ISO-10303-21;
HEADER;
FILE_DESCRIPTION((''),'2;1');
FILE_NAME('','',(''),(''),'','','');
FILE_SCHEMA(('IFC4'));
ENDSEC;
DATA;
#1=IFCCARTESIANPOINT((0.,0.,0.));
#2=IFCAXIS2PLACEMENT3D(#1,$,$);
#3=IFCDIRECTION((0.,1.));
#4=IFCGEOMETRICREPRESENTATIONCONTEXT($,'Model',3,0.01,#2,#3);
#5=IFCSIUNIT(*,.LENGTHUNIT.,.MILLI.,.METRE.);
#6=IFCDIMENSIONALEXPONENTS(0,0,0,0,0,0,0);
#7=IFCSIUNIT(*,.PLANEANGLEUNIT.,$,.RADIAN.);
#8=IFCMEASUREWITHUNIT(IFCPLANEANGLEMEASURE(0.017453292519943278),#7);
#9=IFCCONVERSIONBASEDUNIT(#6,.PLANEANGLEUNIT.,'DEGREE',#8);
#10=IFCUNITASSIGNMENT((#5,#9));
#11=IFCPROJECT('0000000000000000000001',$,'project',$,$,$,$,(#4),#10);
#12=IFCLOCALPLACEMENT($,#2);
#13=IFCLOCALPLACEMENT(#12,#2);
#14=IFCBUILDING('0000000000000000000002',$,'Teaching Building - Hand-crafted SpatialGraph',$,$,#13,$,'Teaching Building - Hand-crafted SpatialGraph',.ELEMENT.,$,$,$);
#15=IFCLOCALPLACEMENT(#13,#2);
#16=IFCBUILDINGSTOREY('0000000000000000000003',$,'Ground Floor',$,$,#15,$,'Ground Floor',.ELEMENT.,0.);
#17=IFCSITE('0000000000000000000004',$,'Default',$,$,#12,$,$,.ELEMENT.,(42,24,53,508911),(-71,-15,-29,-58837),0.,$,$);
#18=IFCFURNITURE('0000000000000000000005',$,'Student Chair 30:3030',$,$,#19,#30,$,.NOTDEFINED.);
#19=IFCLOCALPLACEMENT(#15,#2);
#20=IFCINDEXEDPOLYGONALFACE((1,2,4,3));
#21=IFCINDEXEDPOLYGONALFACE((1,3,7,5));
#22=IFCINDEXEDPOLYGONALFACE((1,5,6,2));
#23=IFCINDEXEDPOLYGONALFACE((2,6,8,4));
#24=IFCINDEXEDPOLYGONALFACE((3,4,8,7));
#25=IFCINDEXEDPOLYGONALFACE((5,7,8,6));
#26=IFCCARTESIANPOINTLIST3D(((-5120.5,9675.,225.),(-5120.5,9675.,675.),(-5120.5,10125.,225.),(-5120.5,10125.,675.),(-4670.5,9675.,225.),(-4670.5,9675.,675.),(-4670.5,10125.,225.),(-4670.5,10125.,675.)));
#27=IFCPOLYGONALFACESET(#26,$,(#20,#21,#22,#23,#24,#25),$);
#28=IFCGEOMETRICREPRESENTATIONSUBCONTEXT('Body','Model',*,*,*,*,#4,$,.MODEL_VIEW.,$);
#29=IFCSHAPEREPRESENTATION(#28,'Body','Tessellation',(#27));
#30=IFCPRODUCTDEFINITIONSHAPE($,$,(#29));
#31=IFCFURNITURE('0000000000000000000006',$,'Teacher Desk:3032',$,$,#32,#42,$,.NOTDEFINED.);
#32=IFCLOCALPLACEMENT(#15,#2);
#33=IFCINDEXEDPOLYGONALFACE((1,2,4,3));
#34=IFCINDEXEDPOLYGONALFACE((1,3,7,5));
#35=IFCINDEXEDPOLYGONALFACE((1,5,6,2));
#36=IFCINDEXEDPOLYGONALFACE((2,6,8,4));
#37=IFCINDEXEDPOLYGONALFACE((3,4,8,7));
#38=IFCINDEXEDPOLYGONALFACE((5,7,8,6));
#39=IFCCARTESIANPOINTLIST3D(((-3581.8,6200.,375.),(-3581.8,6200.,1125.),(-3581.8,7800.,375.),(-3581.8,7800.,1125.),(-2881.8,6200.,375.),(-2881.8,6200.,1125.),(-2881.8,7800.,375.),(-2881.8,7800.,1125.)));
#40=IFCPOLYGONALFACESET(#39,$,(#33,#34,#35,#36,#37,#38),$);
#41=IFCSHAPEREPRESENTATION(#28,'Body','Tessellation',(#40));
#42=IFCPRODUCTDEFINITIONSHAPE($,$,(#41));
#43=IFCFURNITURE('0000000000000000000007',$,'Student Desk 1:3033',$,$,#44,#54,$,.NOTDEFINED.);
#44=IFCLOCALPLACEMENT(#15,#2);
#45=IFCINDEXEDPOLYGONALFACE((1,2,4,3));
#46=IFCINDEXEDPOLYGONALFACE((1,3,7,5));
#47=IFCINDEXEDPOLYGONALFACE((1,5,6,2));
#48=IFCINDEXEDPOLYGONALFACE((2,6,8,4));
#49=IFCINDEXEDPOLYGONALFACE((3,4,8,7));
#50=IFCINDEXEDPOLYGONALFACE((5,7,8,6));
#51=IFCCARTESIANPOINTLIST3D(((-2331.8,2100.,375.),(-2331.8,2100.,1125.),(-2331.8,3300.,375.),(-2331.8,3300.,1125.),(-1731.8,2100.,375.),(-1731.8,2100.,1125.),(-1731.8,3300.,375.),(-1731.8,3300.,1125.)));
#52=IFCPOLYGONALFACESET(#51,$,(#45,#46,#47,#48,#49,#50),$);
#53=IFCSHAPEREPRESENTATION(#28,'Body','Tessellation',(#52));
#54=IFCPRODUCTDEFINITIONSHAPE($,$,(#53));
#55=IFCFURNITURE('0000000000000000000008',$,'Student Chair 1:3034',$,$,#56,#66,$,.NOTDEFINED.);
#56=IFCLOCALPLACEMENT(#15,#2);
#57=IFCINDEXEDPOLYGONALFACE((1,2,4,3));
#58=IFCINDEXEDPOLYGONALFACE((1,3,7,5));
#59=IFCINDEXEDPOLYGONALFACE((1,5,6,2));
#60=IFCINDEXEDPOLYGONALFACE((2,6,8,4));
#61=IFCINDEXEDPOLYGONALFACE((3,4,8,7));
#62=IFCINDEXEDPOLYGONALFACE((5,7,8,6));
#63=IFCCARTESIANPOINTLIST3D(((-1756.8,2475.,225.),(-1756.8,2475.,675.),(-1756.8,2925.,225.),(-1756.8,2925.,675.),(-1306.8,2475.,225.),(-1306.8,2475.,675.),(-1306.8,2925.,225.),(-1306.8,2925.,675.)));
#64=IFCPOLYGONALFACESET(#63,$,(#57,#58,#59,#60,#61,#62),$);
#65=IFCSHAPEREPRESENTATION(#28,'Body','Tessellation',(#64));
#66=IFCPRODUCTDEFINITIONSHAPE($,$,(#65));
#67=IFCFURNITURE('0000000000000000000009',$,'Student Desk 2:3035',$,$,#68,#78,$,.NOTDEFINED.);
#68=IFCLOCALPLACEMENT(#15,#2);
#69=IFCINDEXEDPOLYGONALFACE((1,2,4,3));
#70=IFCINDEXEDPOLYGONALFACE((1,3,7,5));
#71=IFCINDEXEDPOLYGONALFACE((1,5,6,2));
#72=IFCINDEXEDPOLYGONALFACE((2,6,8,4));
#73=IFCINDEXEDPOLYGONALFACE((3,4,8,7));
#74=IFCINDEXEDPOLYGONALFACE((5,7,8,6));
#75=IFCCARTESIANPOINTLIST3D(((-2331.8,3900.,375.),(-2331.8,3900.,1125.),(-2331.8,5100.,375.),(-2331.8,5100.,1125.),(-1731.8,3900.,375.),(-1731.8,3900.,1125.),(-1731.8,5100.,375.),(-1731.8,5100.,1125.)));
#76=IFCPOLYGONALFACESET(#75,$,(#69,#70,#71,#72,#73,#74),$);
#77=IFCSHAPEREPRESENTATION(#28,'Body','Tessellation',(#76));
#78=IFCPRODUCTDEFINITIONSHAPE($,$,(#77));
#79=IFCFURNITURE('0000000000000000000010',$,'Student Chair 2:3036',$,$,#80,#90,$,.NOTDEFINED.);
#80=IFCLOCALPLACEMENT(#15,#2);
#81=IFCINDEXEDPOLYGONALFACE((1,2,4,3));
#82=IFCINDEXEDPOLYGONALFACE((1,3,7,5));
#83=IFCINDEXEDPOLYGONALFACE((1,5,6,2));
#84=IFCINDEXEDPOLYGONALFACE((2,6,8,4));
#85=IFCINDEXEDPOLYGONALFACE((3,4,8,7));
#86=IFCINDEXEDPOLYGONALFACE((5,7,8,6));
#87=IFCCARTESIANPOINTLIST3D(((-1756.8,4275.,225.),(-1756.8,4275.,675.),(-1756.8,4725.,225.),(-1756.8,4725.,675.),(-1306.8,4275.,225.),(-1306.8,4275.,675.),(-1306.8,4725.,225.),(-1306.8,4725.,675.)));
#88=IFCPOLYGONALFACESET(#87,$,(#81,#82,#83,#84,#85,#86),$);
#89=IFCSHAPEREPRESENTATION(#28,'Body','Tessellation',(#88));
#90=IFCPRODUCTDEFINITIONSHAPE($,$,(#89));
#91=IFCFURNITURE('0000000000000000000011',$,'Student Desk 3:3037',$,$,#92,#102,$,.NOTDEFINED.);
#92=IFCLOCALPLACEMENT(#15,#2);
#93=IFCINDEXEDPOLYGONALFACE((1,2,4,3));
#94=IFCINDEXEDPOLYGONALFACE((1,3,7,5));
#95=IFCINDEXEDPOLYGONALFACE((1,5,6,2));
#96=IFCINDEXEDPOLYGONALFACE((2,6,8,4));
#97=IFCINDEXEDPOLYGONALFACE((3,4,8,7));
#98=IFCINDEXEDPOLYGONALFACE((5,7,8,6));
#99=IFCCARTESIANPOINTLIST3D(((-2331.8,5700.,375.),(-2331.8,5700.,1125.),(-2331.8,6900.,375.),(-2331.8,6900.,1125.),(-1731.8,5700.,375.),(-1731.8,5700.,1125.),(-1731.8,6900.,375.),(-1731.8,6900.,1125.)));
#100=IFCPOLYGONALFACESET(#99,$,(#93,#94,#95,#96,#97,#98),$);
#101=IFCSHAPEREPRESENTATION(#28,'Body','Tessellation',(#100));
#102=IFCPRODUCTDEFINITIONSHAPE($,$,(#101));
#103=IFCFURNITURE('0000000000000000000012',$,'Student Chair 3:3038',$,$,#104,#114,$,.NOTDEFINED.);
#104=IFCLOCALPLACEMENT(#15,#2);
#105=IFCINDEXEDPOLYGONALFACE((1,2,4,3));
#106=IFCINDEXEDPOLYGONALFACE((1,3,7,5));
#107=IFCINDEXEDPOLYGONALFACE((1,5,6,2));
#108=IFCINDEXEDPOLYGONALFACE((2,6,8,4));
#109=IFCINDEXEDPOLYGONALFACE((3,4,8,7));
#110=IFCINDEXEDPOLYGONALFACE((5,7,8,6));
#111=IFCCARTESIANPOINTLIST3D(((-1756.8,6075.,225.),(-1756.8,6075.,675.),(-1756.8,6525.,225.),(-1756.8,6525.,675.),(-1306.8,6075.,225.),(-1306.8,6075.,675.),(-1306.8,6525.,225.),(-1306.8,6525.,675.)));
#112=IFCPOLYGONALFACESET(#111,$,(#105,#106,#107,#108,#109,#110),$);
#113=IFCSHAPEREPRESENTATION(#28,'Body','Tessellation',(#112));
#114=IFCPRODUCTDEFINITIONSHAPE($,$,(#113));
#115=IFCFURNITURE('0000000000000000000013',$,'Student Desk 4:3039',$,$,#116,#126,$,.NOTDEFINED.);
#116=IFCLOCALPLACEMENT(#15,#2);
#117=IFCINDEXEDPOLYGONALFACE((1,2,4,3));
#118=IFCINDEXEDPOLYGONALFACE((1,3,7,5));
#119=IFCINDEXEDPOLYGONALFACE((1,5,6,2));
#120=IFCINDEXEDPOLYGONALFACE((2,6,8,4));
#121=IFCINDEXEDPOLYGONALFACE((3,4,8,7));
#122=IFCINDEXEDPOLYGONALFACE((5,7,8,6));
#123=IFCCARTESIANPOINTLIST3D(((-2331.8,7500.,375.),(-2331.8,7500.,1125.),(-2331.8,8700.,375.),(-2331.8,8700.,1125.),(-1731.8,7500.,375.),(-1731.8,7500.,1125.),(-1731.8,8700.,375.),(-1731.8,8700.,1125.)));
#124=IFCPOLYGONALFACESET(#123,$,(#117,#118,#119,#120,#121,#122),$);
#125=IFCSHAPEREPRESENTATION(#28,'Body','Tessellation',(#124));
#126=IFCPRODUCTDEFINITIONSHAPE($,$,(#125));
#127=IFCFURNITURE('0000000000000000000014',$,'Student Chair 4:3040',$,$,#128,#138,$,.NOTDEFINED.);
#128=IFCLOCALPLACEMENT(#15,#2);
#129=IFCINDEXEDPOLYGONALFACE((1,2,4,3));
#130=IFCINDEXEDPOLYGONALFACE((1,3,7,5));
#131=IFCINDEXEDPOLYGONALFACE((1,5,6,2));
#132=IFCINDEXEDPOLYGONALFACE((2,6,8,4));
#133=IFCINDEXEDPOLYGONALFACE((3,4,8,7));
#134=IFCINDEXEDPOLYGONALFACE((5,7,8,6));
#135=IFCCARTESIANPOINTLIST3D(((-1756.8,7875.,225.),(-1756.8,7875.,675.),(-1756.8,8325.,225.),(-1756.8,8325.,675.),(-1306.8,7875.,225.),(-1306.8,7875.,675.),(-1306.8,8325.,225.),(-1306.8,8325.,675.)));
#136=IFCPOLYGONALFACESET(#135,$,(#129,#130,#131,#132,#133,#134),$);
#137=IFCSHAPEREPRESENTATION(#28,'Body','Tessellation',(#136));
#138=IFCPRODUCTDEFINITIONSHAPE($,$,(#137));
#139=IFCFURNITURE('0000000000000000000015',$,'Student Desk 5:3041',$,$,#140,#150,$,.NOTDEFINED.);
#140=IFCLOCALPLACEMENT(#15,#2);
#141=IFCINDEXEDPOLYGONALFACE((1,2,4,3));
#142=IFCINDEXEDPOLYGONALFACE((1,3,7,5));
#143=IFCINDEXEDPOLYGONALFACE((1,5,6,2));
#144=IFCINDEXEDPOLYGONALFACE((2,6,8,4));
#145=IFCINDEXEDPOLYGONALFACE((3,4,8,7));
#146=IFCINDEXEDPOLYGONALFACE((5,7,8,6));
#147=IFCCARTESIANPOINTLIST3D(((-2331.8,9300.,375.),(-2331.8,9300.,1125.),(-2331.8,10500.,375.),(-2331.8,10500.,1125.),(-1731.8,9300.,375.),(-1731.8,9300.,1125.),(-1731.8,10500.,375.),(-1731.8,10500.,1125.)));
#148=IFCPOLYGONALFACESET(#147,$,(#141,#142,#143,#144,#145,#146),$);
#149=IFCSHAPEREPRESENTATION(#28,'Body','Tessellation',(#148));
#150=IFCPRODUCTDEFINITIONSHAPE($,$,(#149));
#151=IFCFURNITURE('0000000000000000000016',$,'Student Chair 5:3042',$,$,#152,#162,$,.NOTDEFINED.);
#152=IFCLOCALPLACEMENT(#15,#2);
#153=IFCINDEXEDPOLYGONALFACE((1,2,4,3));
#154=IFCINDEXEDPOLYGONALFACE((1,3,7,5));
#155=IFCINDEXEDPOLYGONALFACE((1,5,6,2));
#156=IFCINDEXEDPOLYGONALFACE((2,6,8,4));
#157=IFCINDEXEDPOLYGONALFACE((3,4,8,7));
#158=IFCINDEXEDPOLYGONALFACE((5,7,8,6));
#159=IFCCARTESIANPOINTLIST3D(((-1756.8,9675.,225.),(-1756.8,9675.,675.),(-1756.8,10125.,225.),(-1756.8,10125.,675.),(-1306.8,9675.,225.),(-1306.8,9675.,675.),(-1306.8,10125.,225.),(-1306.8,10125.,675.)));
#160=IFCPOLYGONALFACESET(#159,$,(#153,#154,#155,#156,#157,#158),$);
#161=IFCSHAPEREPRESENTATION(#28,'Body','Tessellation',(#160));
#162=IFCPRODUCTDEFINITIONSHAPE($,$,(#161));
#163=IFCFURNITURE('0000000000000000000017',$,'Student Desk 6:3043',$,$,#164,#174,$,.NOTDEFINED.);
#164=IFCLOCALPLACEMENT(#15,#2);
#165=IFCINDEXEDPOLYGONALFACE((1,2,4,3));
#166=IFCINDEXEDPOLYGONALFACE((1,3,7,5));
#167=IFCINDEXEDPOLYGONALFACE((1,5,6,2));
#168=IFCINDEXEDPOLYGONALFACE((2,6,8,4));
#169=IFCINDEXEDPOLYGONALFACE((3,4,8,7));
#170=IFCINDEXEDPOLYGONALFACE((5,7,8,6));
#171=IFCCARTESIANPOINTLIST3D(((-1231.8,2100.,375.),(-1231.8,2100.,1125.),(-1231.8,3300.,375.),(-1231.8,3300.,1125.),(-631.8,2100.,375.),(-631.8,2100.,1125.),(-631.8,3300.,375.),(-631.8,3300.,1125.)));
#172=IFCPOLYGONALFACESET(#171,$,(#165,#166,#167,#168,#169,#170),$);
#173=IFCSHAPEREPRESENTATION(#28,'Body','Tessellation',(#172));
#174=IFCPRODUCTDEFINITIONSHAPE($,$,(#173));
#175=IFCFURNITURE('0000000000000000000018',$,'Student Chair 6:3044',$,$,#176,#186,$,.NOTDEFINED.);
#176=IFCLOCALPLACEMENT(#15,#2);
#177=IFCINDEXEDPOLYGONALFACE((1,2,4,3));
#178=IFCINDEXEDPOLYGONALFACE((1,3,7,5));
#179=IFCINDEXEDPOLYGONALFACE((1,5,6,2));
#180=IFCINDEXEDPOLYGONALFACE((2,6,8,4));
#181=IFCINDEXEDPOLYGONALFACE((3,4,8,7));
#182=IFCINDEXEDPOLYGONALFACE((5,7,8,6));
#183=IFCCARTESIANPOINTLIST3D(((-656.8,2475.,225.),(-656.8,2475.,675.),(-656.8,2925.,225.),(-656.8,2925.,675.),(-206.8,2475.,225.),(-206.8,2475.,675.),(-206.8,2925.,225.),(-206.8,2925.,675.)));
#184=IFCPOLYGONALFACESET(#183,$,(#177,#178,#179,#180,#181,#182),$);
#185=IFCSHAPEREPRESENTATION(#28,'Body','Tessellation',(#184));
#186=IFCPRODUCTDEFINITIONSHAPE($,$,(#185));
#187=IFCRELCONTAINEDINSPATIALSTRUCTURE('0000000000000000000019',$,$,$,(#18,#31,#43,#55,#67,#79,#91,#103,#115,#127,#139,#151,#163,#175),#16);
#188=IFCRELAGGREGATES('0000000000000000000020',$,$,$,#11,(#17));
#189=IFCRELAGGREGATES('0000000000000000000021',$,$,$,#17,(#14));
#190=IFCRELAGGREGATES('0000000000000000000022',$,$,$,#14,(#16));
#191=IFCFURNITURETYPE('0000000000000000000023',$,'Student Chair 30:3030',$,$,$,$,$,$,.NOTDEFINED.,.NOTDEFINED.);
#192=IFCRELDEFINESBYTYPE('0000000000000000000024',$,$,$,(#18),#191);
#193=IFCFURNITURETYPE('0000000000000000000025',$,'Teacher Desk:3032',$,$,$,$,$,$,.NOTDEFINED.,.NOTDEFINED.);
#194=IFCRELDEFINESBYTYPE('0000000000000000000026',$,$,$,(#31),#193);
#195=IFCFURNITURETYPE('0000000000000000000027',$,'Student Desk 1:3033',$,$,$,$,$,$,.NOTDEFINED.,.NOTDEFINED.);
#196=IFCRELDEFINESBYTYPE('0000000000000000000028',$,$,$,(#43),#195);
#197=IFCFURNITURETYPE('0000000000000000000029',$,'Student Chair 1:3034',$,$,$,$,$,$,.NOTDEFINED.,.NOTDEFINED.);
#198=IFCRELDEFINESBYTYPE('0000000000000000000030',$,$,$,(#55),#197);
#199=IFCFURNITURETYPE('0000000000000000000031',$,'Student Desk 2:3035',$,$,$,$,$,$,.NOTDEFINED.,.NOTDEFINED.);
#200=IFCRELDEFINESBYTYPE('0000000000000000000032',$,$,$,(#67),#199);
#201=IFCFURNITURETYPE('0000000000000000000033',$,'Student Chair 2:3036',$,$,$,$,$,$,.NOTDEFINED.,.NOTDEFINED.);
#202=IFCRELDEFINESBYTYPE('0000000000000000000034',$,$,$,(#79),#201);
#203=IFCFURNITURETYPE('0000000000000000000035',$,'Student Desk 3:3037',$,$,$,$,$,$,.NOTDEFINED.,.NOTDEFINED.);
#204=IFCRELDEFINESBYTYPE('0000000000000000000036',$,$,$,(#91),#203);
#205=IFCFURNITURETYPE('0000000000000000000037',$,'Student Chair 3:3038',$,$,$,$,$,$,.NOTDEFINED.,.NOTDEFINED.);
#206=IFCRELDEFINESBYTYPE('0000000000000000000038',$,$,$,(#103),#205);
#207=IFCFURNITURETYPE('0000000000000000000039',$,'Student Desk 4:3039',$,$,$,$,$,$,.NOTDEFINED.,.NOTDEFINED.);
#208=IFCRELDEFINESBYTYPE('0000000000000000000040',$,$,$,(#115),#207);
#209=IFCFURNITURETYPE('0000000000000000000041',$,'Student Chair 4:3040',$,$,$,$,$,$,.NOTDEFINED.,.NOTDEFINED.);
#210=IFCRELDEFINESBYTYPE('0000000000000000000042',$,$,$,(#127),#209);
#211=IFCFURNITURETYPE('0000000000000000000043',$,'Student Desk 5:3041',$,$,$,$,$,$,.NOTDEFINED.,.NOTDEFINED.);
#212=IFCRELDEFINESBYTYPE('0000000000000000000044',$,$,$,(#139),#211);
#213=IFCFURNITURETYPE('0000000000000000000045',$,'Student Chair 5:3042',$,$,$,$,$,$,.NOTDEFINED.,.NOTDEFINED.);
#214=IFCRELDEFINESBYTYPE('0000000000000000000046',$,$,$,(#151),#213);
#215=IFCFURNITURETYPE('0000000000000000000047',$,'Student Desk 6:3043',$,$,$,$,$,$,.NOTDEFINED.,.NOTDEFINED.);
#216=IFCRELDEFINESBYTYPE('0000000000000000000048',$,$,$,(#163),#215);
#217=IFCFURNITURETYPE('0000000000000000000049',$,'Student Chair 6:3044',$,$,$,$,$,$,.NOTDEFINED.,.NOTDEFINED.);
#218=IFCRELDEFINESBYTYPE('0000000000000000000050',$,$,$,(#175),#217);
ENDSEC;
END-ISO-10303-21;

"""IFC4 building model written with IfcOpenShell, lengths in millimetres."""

from ifc_helpers import new_model, entity, si_unit, converted_unit, direction, frame, frame_2d, origin, origin_2d_with_axis, place, context, subcontext, project, spatial, rectangle, extrude, type_object, element, save


model = new_model("IFC4")

# Units and contexts
model_context = context("Model", 3, precision=0.01, world=origin(), true_north=direction((0.0, 1.0)))
body_context = subcontext(model_context, "Body", "Model", "MODEL_VIEW")
ifc_project = project(units=[si_unit("LENGTHUNIT", "METRE", prefix="MILLI"), converted_unit("PLANEANGLEUNIT", "DEGREE", entity("IfcPlaneAngleMeasure", 0.017453292519943278), si_unit("PLANEANGLEUNIT", "RADIAN"), dimensions=[0, 0, 0, 0, 0, 0, 0])], contexts=[model_context])

# Site, building, storey
site_placement = place(None, origin())
site = spatial("IfcSite", under=ifc_project, at=site_placement, Name="Default", CompositionType="ELEMENT", RefLatitude=(42, 24, 53, 508911), RefLongitude=(-71, -15, -29, -58837), RefElevation=0.0)
building_placement = place(site_placement, origin())
building = spatial("IfcBuilding", under=site, at=building_placement, Name="Teaching Building - Hand-crafted SpatialGraph", LongName="Teaching Building - Hand-crafted SpatialGraph", CompositionType="ELEMENT")
storey_placement = place(building_placement, origin())
storey = spatial("IfcBuildingStorey", under=building, at=storey_placement, Name="Ground Floor", LongName="Ground Floor", CompositionType="ELEMENT", Elevation=0.0)

# Furniture
furniture_type_1 = type_object("IfcFurnitureType", Name="Student Chair 30:3030", PredefinedType="NOTDEFINED")
furniture_1_placement = place(storey_placement, origin())
element("IfcFurniture", 1, at=furniture_1_placement, inside=storey, type_object=furniture_type_1, Name="Student Chair 30:3030", PredefinedType="NOTDEFINED", context=body_context, shape_type="SweptSolid", body=[
    extrude(rectangle(XDim=450.0, YDim=450.0, at=frame_2d((0.0, 0.0), x_axis=(1.0, 0.0))), frame((-4895.5, 9900.0, 225.0)), (0.0, 0.0, 1.0), 450.0),
])
furniture_type_2 = type_object("IfcFurnitureType", Name="Teacher Desk:3032", PredefinedType="NOTDEFINED")
furniture_2_placement = place(storey_placement, origin())
element("IfcFurniture", 2, at=furniture_2_placement, inside=storey, type_object=furniture_type_2, Name="Teacher Desk:3032", PredefinedType="NOTDEFINED", context=body_context, shape_type="SweptSolid", body=[
    extrude(rectangle(XDim=1600.0, YDim=700.0, at=origin_2d_with_axis()), frame((-3231.8, 7000.0, 375.0), z_axis=(0.0, 0.0, 1.0), x_axis=(0.0, 1.0, 0.0)), (0.0, 0.0, 1.0), 750.0),
])
furniture_type_3 = type_object("IfcFurnitureType", Name="Student Desk 1:3033", PredefinedType="NOTDEFINED")
furniture_3_placement = place(storey_placement, origin())
element("IfcFurniture", 3, at=furniture_3_placement, inside=storey, type_object=furniture_type_3, Name="Student Desk 1:3033", PredefinedType="NOTDEFINED", context=body_context, shape_type="SweptSolid", body=[
    extrude(rectangle(XDim=1200.0, YDim=600.0, at=origin_2d_with_axis()), frame((-2031.8, 2700.0, 375.0), z_axis=(0.0, 0.0, 1.0), x_axis=(0.0, 1.0, 0.0)), (0.0, 0.0, 1.0), 750.0),
])
furniture_type_4 = type_object("IfcFurnitureType", Name="Student Chair 1:3034", PredefinedType="NOTDEFINED")
furniture_4_placement = place(storey_placement, origin())
element("IfcFurniture", 4, at=furniture_4_placement, inside=storey, type_object=furniture_type_4, Name="Student Chair 1:3034", PredefinedType="NOTDEFINED", context=body_context, shape_type="SweptSolid", body=[
    extrude(rectangle(XDim=450.0, YDim=450.0, at=origin_2d_with_axis()), frame((-1531.8, 2700.0, 225.0)), (0.0, 0.0, 1.0), 450.0),
])
furniture_type_5 = type_object("IfcFurnitureType", Name="Student Desk 2:3035", PredefinedType="NOTDEFINED")
furniture_5_placement = place(storey_placement, origin())
element("IfcFurniture", 5, at=furniture_5_placement, inside=storey, type_object=furniture_type_5, Name="Student Desk 2:3035", PredefinedType="NOTDEFINED", context=body_context, shape_type="SweptSolid", body=[
    extrude(rectangle(XDim=1200.0, YDim=600.0, at=frame_2d((0.0, 0.0), x_axis=(1.0, 0.0))), frame((-2031.8, 4500.0, 375.0), z_axis=(0.0, 0.0, 1.0), x_axis=(0.0, 1.0, 0.0)), (0.0, 0.0, 1.0), 750.0),
])
furniture_type_6 = type_object("IfcFurnitureType", Name="Student Chair 2:3036", PredefinedType="NOTDEFINED")
furniture_6_placement = place(storey_placement, origin())
element("IfcFurniture", 6, at=furniture_6_placement, inside=storey, type_object=furniture_type_6, Name="Student Chair 2:3036", PredefinedType="NOTDEFINED", context=body_context, shape_type="SweptSolid", body=[
    extrude(rectangle(XDim=450.0, YDim=450.0, at=origin_2d_with_axis()), frame((-1531.8, 4500.0, 225.0)), (0.0, 0.0, 1.0), 450.0),
])
furniture_type_7 = type_object("IfcFurnitureType", Name="Student Desk 3:3037", PredefinedType="NOTDEFINED")
furniture_7_placement = place(storey_placement, origin())
element("IfcFurniture", 7, at=furniture_7_placement, inside=storey, type_object=furniture_type_7, Name="Student Desk 3:3037", PredefinedType="NOTDEFINED", context=body_context, shape_type="SweptSolid", body=[
    extrude(rectangle(XDim=1200.0, YDim=600.0, at=origin_2d_with_axis()), frame((-2031.8, 6300.0, 375.0), z_axis=(0.0, 0.0, 1.0), x_axis=(0.0, 1.0, 0.0)), (0.0, 0.0, 1.0), 750.0),
])
furniture_type_8 = type_object("IfcFurnitureType", Name="Student Chair 3:3038", PredefinedType="NOTDEFINED")
furniture_8_placement = place(storey_placement, origin())
element("IfcFurniture", 8, at=furniture_8_placement, inside=storey, type_object=furniture_type_8, Name="Student Chair 3:3038", PredefinedType="NOTDEFINED", context=body_context, shape_type="SweptSolid", body=[
    extrude(rectangle(XDim=450.0, YDim=450.0, at=origin_2d_with_axis()), frame((-1531.8, 6300.0, 225.0)), (0.0, 0.0, 1.0), 450.0),
])
furniture_type_9 = type_object("IfcFurnitureType", Name="Student Desk 4:3039", PredefinedType="NOTDEFINED")
furniture_9_placement = place(storey_placement, origin())
element("IfcFurniture", 9, at=furniture_9_placement, inside=storey, type_object=furniture_type_9, Name="Student Desk 4:3039", PredefinedType="NOTDEFINED", context=body_context, shape_type="SweptSolid", body=[
    extrude(rectangle(XDim=1200.0, YDim=600.0, at=origin_2d_with_axis()), frame((-2031.8, 8100.0, 375.0), z_axis=(0.0, 0.0, 1.0), x_axis=(0.0, 1.0, 0.0)), (0.0, 0.0, 1.0), 750.0),
])
furniture_type_10 = type_object("IfcFurnitureType", Name="Student Chair 4:3040", PredefinedType="NOTDEFINED")
furniture_10_placement = place(storey_placement, origin())
element("IfcFurniture", 10, at=furniture_10_placement, inside=storey, type_object=furniture_type_10, Name="Student Chair 4:3040", PredefinedType="NOTDEFINED", context=body_context, shape_type="SweptSolid", body=[
    extrude(rectangle(XDim=450.0, YDim=450.0, at=origin_2d_with_axis()), frame((-1531.8, 8100.0, 225.0)), (0.0, 0.0, 1.0), 450.0),
])
furniture_type_11 = type_object("IfcFurnitureType", Name="Student Desk 5:3041", PredefinedType="NOTDEFINED")
furniture_11_placement = place(storey_placement, origin())
element("IfcFurniture", 11, at=furniture_11_placement, inside=storey, type_object=furniture_type_11, Name="Student Desk 5:3041", PredefinedType="NOTDEFINED", context=body_context, shape_type="SweptSolid", body=[
    extrude(rectangle(XDim=1200.0, YDim=600.0, at=origin_2d_with_axis()), frame((-2031.8, 9900.0, 375.0), z_axis=(0.0, 0.0, 1.0), x_axis=(0.0, 1.0, 0.0)), (0.0, 0.0, 1.0), 750.0),
])
furniture_type_12 = type_object("IfcFurnitureType", Name="Student Chair 5:3042", PredefinedType="NOTDEFINED")
furniture_12_placement = place(storey_placement, origin())
element("IfcFurniture", 12, at=furniture_12_placement, inside=storey, type_object=furniture_type_12, Name="Student Chair 5:3042", PredefinedType="NOTDEFINED", context=body_context, shape_type="SweptSolid", body=[
    extrude(rectangle(XDim=450.0, YDim=450.0, at=frame_2d((0.0, 0.0), x_axis=(1.0, 0.0))), frame((-1531.8, 9900.0, 225.0)), (0.0, 0.0, 1.0), 450.0),
])
furniture_type_13 = type_object("IfcFurnitureType", Name="Student Desk 6:3043", PredefinedType="NOTDEFINED")
furniture_13_placement = place(storey_placement, origin())
element("IfcFurniture", 13, at=furniture_13_placement, inside=storey, type_object=furniture_type_13, Name="Student Desk 6:3043", PredefinedType="NOTDEFINED", context=body_context, shape_type="SweptSolid", body=[
    extrude(rectangle(XDim=1200.0, YDim=600.0, at=frame_2d((0.0, 0.0), x_axis=(1.0, 0.0))), frame((-931.8, 2700.0, 375.0), z_axis=(0.0, 0.0, 1.0), x_axis=(0.0, 1.0, 0.0)), (0.0, 0.0, 1.0), 750.0),
])
furniture_type_14 = type_object("IfcFurnitureType", Name="Student Chair 6:3044", PredefinedType="NOTDEFINED")
furniture_14_placement = place(storey_placement, origin())
element("IfcFurniture", 14, at=furniture_14_placement, inside=storey, type_object=furniture_type_14, Name="Student Chair 6:3044", PredefinedType="NOTDEFINED", context=body_context, shape_type="SweptSolid", body=[
    extrude(rectangle(XDim=450.0, YDim=450.0, at=origin_2d_with_axis()), frame((-431.8, 2700.0, 225.0)), (0.0, 0.0, 1.0), 450.0),
])

save(model, "model.ifc")
